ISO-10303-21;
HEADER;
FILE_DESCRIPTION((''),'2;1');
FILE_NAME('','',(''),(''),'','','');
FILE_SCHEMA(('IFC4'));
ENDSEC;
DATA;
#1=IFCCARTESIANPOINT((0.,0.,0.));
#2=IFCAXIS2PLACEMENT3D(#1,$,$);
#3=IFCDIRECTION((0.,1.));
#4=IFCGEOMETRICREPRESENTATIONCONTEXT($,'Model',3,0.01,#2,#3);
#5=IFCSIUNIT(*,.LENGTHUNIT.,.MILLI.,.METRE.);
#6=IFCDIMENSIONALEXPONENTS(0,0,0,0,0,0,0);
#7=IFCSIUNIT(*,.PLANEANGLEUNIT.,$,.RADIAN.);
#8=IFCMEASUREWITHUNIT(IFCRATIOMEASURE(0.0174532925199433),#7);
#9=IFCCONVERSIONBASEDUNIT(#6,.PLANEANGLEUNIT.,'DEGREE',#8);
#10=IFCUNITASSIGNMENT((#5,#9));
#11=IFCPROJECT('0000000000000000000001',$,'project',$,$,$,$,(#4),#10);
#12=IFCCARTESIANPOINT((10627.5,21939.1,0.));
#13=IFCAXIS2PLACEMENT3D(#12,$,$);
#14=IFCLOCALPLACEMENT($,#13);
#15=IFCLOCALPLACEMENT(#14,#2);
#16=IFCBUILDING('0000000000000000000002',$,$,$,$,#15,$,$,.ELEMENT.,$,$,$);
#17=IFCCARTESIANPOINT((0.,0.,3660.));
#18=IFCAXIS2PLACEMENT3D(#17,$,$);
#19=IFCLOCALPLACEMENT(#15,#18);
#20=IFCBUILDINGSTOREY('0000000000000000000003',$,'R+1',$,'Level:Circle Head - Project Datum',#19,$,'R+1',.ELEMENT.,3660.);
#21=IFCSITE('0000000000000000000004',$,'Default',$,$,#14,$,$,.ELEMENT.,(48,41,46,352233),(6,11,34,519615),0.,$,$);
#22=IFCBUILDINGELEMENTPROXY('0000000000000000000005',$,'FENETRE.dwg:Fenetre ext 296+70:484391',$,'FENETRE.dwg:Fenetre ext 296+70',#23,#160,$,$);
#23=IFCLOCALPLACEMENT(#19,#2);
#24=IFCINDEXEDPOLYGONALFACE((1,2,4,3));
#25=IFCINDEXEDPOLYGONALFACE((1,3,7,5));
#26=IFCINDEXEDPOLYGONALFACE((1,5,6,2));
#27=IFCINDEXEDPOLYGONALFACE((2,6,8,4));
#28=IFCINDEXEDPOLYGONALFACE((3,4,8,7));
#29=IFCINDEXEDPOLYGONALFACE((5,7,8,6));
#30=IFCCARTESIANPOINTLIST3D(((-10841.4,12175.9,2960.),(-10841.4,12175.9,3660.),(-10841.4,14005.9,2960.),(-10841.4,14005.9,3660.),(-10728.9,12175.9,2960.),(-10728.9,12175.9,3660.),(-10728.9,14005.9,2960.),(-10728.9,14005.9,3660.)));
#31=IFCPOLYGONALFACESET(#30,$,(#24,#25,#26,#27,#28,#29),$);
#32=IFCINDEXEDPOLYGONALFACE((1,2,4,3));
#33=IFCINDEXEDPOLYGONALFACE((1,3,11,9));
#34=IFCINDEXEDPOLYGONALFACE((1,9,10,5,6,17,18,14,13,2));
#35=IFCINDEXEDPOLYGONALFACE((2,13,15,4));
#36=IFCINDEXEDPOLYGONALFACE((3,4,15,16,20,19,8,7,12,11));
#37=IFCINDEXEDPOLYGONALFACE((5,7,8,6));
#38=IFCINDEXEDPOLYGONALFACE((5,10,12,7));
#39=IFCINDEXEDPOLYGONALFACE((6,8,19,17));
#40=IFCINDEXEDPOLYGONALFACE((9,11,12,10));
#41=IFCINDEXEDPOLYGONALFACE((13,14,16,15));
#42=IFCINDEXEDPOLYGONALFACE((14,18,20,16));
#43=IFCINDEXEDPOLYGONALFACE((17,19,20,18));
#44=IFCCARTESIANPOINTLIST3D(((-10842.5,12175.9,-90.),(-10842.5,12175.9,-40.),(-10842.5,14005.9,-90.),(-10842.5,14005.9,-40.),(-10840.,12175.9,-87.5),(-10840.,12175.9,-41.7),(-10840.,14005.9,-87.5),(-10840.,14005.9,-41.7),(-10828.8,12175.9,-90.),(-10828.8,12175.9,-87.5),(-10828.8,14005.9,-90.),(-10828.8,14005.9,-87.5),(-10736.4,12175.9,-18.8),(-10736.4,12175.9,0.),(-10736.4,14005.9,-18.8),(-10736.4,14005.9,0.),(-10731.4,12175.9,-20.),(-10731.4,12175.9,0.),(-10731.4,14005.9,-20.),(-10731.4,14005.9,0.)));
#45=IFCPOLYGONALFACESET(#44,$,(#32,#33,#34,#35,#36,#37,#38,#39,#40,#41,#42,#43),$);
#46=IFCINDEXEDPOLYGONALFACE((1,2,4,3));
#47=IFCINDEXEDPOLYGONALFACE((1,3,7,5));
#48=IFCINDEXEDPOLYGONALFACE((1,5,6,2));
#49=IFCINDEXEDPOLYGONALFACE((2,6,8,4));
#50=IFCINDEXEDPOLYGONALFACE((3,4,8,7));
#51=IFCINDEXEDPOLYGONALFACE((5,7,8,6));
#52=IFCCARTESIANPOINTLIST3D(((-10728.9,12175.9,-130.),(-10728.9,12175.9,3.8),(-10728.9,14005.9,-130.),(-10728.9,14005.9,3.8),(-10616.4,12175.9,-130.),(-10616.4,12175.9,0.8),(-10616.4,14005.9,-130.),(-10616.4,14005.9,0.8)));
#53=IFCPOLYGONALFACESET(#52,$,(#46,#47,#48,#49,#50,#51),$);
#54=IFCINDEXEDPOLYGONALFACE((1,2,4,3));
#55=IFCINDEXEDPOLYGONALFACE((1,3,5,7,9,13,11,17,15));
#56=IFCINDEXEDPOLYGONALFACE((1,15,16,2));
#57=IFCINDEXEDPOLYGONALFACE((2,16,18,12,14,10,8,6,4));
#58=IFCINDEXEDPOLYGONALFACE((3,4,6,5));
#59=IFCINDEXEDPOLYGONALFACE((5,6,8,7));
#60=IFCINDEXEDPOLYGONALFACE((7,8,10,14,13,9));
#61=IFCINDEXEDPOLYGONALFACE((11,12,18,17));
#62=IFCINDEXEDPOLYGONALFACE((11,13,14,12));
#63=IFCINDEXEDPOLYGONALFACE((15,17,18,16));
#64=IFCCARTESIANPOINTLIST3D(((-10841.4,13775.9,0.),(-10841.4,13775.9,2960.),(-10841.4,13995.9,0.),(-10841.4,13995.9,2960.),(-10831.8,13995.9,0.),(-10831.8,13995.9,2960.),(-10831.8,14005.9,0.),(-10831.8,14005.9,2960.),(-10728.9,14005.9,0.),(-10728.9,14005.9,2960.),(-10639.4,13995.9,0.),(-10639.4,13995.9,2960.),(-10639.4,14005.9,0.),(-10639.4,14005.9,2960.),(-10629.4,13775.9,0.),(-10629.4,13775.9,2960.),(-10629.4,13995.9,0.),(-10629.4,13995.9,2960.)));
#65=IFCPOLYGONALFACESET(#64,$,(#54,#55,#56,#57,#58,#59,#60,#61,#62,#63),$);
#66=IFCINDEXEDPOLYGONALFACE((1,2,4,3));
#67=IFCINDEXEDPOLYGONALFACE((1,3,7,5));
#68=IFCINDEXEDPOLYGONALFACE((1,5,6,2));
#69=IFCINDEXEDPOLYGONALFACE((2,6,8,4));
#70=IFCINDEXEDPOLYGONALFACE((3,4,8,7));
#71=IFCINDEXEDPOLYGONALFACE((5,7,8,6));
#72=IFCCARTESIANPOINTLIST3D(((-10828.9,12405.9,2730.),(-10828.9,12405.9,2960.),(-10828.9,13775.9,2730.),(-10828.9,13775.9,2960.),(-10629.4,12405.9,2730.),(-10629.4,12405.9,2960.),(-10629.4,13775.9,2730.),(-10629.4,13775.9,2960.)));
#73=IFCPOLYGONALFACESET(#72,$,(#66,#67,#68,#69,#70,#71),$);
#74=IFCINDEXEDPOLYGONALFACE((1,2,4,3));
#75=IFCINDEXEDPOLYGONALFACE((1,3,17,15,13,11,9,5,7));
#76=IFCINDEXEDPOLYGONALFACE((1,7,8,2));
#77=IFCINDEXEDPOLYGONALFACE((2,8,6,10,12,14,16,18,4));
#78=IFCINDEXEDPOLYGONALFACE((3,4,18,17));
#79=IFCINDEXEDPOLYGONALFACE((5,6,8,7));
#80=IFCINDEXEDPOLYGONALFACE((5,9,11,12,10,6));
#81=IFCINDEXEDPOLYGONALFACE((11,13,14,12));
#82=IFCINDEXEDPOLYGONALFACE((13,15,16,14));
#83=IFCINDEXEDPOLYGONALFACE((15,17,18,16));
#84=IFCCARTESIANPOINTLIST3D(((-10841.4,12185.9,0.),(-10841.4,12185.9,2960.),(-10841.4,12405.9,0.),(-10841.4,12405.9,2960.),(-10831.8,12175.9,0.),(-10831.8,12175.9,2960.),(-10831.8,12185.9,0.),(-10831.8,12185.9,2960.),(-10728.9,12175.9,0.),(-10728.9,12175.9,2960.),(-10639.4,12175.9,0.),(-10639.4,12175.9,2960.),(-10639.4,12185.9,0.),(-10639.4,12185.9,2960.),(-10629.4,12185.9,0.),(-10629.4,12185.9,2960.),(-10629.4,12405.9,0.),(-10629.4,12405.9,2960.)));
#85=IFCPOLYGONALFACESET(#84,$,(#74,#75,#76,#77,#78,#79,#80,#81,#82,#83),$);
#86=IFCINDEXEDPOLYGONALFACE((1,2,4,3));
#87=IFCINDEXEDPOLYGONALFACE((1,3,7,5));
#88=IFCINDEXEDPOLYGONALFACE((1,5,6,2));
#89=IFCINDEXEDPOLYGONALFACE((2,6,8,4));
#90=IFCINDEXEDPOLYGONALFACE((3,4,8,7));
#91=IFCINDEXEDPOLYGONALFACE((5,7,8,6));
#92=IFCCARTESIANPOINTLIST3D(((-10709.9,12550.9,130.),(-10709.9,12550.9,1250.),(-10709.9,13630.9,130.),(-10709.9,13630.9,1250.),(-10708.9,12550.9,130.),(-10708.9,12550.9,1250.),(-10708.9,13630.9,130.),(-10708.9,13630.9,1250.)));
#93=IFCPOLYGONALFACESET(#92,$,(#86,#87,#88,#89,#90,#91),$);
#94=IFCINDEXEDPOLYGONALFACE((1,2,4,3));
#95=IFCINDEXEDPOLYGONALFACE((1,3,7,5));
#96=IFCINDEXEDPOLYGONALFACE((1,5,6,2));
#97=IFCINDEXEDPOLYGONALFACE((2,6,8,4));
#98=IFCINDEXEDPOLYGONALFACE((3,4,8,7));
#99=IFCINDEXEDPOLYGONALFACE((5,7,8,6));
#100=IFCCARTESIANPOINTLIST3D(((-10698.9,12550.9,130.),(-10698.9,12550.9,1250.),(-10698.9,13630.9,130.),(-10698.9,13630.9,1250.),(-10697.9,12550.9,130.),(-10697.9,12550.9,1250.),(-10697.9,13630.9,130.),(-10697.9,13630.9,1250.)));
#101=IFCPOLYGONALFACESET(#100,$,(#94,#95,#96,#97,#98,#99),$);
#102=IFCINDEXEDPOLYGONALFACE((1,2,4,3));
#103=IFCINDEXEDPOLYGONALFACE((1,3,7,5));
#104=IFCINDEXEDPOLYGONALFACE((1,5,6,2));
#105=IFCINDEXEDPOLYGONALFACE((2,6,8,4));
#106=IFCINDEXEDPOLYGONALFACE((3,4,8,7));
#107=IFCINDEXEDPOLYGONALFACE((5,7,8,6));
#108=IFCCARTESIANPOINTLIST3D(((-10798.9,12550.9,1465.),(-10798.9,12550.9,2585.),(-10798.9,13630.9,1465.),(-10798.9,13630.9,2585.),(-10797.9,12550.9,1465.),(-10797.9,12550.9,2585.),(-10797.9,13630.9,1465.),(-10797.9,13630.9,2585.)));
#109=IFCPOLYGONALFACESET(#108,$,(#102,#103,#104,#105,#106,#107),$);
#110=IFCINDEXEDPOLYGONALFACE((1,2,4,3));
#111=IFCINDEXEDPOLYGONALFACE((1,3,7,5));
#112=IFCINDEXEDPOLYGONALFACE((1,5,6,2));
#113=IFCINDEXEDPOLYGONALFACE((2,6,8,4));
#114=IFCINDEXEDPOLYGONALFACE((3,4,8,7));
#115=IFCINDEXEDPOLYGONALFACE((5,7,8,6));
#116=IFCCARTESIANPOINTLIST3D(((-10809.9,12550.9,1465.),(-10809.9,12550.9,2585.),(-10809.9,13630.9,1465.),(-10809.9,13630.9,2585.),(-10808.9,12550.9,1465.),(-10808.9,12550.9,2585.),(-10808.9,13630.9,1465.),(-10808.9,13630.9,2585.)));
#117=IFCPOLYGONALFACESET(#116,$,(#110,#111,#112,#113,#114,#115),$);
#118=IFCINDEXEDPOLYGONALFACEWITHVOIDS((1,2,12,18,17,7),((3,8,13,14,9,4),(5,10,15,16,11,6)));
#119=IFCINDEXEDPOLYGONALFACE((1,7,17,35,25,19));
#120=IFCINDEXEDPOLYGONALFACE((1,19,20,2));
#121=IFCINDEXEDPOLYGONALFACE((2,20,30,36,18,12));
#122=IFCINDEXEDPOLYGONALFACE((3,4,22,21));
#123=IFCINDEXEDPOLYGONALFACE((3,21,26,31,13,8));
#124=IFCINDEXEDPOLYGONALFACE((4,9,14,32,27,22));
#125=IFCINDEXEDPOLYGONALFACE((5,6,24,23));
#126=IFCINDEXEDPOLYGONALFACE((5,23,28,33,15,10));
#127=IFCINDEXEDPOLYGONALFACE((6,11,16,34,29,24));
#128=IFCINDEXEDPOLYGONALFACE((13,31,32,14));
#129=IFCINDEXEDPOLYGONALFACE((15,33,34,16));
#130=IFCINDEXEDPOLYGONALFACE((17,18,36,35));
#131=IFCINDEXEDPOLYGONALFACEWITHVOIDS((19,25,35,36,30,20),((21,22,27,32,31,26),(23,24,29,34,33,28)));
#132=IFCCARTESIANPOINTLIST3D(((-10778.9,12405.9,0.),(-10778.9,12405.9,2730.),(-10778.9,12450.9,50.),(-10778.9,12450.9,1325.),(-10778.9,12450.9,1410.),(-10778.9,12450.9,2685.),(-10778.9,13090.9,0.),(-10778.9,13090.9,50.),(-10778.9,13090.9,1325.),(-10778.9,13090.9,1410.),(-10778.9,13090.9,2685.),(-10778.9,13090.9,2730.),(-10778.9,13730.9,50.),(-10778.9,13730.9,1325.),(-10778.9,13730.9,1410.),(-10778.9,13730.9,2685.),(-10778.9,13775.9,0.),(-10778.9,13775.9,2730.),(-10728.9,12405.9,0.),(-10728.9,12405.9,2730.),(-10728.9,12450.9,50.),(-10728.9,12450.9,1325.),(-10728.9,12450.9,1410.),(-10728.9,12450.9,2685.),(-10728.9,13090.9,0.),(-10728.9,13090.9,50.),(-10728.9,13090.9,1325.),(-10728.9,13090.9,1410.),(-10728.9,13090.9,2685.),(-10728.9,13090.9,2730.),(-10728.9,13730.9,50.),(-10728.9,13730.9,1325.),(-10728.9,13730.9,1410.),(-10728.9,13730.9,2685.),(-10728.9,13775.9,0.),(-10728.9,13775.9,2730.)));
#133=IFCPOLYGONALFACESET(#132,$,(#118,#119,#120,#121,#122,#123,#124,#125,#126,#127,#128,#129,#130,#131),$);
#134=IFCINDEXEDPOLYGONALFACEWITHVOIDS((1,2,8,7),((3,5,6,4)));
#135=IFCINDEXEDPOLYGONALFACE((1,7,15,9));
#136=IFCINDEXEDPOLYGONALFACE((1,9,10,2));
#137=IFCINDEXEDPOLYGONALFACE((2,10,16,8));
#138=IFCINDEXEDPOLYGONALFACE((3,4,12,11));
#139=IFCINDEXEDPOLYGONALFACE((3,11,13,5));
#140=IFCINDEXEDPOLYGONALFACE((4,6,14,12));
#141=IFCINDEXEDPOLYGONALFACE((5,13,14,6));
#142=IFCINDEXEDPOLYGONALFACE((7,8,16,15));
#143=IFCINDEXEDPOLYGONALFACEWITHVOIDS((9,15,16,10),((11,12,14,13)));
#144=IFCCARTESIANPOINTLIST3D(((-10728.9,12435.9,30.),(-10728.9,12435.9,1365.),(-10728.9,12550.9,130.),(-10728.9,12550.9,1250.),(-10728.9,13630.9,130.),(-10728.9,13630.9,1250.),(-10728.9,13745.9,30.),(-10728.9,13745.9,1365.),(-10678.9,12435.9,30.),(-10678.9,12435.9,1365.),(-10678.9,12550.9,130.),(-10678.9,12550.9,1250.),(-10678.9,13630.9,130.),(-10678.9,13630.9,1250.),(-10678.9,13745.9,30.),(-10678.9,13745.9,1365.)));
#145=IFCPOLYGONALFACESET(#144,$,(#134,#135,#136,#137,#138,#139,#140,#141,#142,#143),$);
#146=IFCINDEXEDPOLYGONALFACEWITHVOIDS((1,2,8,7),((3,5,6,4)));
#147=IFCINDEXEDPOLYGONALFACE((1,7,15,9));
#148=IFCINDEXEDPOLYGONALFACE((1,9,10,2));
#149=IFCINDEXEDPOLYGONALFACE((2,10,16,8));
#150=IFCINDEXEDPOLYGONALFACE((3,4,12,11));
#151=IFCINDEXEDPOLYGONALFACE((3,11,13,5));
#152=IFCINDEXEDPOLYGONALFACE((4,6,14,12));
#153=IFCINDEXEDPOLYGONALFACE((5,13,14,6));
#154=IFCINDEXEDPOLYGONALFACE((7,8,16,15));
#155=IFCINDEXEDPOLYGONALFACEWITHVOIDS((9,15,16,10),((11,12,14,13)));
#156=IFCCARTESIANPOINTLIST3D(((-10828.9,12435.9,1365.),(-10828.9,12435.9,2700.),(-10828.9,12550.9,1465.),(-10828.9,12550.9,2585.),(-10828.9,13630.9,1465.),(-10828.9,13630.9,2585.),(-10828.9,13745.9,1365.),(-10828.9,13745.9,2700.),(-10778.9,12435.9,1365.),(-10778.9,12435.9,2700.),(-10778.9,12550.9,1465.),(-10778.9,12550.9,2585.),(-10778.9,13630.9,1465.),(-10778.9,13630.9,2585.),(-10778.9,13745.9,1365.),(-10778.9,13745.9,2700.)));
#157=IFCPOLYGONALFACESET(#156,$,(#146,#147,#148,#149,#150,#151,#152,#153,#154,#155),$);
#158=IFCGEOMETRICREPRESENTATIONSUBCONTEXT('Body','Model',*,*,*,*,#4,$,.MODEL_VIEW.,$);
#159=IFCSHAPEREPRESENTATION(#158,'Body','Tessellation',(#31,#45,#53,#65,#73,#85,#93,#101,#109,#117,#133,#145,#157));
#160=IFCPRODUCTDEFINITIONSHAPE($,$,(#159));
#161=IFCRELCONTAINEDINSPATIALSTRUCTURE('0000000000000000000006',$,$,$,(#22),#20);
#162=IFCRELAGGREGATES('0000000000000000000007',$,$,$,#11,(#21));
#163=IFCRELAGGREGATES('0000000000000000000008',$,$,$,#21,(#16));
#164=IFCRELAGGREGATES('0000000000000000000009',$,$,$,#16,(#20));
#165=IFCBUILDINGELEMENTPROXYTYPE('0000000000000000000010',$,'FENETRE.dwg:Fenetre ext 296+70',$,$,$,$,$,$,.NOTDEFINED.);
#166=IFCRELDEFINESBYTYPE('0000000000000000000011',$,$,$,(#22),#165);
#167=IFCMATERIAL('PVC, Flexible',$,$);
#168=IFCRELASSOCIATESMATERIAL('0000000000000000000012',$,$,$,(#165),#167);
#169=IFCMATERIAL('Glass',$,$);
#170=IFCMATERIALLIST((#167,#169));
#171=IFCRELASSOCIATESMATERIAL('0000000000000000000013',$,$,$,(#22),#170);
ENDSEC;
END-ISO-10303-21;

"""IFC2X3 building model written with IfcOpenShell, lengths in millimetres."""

from ifc_helpers import new_model, entity, si_unit, converted_unit, direction, frame, frame_2d, origin, origin_2d_with_axis, place, context, subcontext, project, spatial, polyline, rectangle, outline, extrude, source, transform, mapped, material, material_list, type_object, type_shapes, element, save


model = new_model("IFC2X3")

# Units and contexts
model_context = context("Model", 3, precision=0.01, world=origin(), true_north=direction((0.0, 1.0)))
body_context = subcontext(model_context, "Body", "Model", "MODEL_VIEW")
ifc_project = project(units=[si_unit("LENGTHUNIT", "METRE", prefix="MILLI"), converted_unit("PLANEANGLEUNIT", "DEGREE", entity("IfcRatioMeasure", 0.0174532925199433), si_unit("PLANEANGLEUNIT", "RADIAN"), dimensions=[0, 0, 0, 0, 0, 0, 0])], contexts=[model_context])

# Site, building, storey
site_placement = place(None, frame((10627.5, 21939.1, 0.0)))
site = spatial("IfcSite", under=ifc_project, at=site_placement, Name="Default", CompositionType="ELEMENT", RefLatitude=(48, 41, 46, 352233), RefLongitude=(6, 11, 34, 519615), RefElevation=0.0)
building_placement = place(site_placement, origin())
building = spatial("IfcBuilding", under=site, at=building_placement, CompositionType="ELEMENT")
storey_placement = place(building_placement, frame((0.0, 0.0, 3660.0)))
storey = spatial("IfcBuildingStorey", under=building, at=storey_placement, Name="R+1", ObjectType="Level:Circle Head - Project Datum", LongName="R+1", CompositionType="ELEMENT", Elevation=3660.0)

# Building element proxy
ifc_material_1 = material(Name="PVC, Flexible")
ifc_material_2 = material(Name="Glass")
building_element_proxy_type_1 = type_object("IfcBuildingElementProxyType", Name="FENETRE.dwg:Fenetre ext 296+70", PredefinedType="NOTDEFINED", material=ifc_material_1)
shared_shape_1 = source(origin(), body_context, "Body", "SweptSolid", [
    extrude(rectangle(XDim=1830.0, YDim=112.5, at=origin_2d_with_axis()), frame((-10.4, 56.3, 2960.0), z_axis=(0.0, 0.0, 1.0), x_axis=(-1.0, 0.0, 0.0)), (0.0, 0.0, 1.0), 700.0),
    extrude(outline(polyline([(-68.6, -14.4), (-72.5, -34.0), (-67.6, -35.0), (-63.9, -16.6), (44.3, -16.6), (54.1, 32.5), (40.6, 35.2), (40.1, 32.7), (51.2, 30.5), (42.2, -14.4), (-68.6, -14.4)])), frame((-925.4, 66.9, -47.5), z_axis=(-1.0, 0.0, 0.0), x_axis=(0.0, 0.980599, -0.196027)), (0.0, 0.0, -1.0), 1830.0),
    extrude(outline(polyline([(-64.7, -56.3), (66.2, -56.3), (66.2, 56.3), (-67.7, 56.3), (-64.7, -56.3)])), frame((-925.4, -56.3, -63.8), z_axis=(1.0, 0.0, 0.0), x_axis=(0.0, 0.0, -1.0)), (0.0, 0.0, 1.0), 1830.0),
    extrude(outline(polyline([(-55.6, 97.0), (-55.6, -5.9), (-55.6, -95.4), (-45.6, -95.4), (-45.6, -105.4), (174.4, -105.4), (174.4, 106.6), (-45.6, 106.6), (-45.6, 97.0), (-55.6, 97.0)])), frame((849.0, 5.9, 0.0), z_axis=(0.0, 0.0, -1.0), x_axis=(-1.0, 0.0, 0.0)), (0.0, 0.0, -1.0), 2960.0),
    extrude(rectangle(XDim=199.5, YDim=1370.0, at=origin_2d_with_axis()), frame((-10.4, 0.3, 2730.0), z_axis=(0.0, 0.0, 1.0), x_axis=(0.0, 1.0, 0.0)), (0.0, 0.0, 1.0), 230.0),
    extrude(outline(polyline([(-97.0, -55.6), (5.9, -55.6), (95.4, -55.6), (95.4, -45.6), (105.4, -45.6), (105.4, 174.4), (-106.6, 174.4), (-106.6, -45.6), (-97.0, -45.6), (-97.0, -55.6)])), frame((-869.9, 5.9, 0.0), z_axis=(0.0, 0.0, 1.0), x_axis=(0.0, -1.0, 0.0)), (0.0, 0.0, 1.0), 2960.0),
    extrude(rectangle(XDim=1.0, YDim=1080.0, at=origin_2d_with_axis()), frame((-10.4, -19.5, 130.0), z_axis=(0.0, 0.0, 1.0), x_axis=(0.0, 1.0, 0.0)), (0.0, 0.0, 1.0), 1120.0),
    extrude(rectangle(XDim=1.0, YDim=1080.0, at=frame_2d((0.0, 0.0), x_axis=(1.0, 0.0))), frame((-10.4, -30.5, 130.0), z_axis=(0.0, 0.0, 1.0), x_axis=(0.0, 1.0, 0.0)), (0.0, 0.0, 1.0), 1120.0),
    extrude(rectangle(XDim=1.0, YDim=1080.0, at=frame_2d((0.0, 0.0), x_axis=(1.0, 0.0))), frame((-10.4, 69.5, 1465.0), z_axis=(0.0, 0.0, 1.0), x_axis=(0.0, 1.0, 0.0)), (0.0, 0.0, 1.0), 1120.0),
    extrude(rectangle(XDim=1.0, YDim=1080.0, at=frame_2d((0.0, 0.0), x_axis=(1.0, 0.0))), frame((-10.4, 80.5, 1465.0), z_axis=(0.0, 0.0, 1.0), x_axis=(0.0, 1.0, 0.0)), (0.0, 0.0, 1.0), 1120.0),
    extrude(outline(polyline([(-685.0, -1365.0), (0.0, -1365.0), (685.0, -1365.0), (685.0, 1365.0), (0.0, 1365.0), (-685.0, 1365.0), (-685.0, -1365.0)]), holes=[polyline([(-640.0, -1320.0), (-640.0, -45.0), (0.0, -45.0), (640.0, -45.0), (640.0, -1320.0), (0.0, -1320.0), (-640.0, -1320.0)]), polyline([(-640.0, 40.0), (-640.0, 1315.0), (0.0, 1315.0), (640.0, 1315.0), (640.0, 40.0), (0.0, 40.0), (-640.0, 40.0)])]), frame((-10.4, 0.0, 1365.0), z_axis=(0.0, 1.0, 0.0), x_axis=(1.0, 0.0, 0.0)), (0.0, 0.0, 1.0), 50.0),
    extrude(outline(polyline([(-655.0, -667.5), (655.0, -667.5), (655.0, 667.5), (-655.0, 667.5), (-655.0, -667.5)]), holes=[polyline([(-540.0, 552.5), (540.0, 552.5), (540.0, -567.5), (-540.0, -567.5), (-540.0, 552.5)])]), frame((-10.4, -50.0, 697.5), z_axis=(0.0, 1.0, 0.0), x_axis=(-1.0, 0.0, 0.0)), (0.0, 0.0, 1.0), 50.0),
    extrude(outline(polyline([(-655.0, -667.5), (655.0, -667.5), (655.0, 667.5), (-655.0, 667.5), (-655.0, -667.5)]), holes=[polyline([(-540.0, 552.5), (540.0, 552.5), (540.0, -567.5), (-540.0, -567.5), (-540.0, 552.5)])]), frame((-10.4, 50.0, 2032.5), z_axis=(0.0, 1.0, 0.0), x_axis=(-1.0, 0.0, 0.0)), (0.0, 0.0, 1.0), 50.0),
])
type_shapes(building_element_proxy_type_1, [shared_shape_1])
ifc_material_list_1 = material_list([ifc_material_1, ifc_material_2])
proxy_1_placement = place(storey_placement, frame((-10728.9, 13101.3, 0.0), z_axis=(0.0, 0.0, 1.0), x_axis=(0.0, 1.0, 0.0)))
element("IfcBuildingElementProxy", 1, at=proxy_1_placement, inside=storey, type_object=building_element_proxy_type_1, material=ifc_material_list_1, Name="FENETRE.dwg:Fenetre ext 296+70:484391", ObjectType="FENETRE.dwg:Fenetre ext 296+70", context=body_context, shape_type="MappedRepresentation", body=[
    mapped(shared_shape_1, transform((0.0, 0.0, 0.0), scale=1.0)),
])

save(model, "model.ifc")
